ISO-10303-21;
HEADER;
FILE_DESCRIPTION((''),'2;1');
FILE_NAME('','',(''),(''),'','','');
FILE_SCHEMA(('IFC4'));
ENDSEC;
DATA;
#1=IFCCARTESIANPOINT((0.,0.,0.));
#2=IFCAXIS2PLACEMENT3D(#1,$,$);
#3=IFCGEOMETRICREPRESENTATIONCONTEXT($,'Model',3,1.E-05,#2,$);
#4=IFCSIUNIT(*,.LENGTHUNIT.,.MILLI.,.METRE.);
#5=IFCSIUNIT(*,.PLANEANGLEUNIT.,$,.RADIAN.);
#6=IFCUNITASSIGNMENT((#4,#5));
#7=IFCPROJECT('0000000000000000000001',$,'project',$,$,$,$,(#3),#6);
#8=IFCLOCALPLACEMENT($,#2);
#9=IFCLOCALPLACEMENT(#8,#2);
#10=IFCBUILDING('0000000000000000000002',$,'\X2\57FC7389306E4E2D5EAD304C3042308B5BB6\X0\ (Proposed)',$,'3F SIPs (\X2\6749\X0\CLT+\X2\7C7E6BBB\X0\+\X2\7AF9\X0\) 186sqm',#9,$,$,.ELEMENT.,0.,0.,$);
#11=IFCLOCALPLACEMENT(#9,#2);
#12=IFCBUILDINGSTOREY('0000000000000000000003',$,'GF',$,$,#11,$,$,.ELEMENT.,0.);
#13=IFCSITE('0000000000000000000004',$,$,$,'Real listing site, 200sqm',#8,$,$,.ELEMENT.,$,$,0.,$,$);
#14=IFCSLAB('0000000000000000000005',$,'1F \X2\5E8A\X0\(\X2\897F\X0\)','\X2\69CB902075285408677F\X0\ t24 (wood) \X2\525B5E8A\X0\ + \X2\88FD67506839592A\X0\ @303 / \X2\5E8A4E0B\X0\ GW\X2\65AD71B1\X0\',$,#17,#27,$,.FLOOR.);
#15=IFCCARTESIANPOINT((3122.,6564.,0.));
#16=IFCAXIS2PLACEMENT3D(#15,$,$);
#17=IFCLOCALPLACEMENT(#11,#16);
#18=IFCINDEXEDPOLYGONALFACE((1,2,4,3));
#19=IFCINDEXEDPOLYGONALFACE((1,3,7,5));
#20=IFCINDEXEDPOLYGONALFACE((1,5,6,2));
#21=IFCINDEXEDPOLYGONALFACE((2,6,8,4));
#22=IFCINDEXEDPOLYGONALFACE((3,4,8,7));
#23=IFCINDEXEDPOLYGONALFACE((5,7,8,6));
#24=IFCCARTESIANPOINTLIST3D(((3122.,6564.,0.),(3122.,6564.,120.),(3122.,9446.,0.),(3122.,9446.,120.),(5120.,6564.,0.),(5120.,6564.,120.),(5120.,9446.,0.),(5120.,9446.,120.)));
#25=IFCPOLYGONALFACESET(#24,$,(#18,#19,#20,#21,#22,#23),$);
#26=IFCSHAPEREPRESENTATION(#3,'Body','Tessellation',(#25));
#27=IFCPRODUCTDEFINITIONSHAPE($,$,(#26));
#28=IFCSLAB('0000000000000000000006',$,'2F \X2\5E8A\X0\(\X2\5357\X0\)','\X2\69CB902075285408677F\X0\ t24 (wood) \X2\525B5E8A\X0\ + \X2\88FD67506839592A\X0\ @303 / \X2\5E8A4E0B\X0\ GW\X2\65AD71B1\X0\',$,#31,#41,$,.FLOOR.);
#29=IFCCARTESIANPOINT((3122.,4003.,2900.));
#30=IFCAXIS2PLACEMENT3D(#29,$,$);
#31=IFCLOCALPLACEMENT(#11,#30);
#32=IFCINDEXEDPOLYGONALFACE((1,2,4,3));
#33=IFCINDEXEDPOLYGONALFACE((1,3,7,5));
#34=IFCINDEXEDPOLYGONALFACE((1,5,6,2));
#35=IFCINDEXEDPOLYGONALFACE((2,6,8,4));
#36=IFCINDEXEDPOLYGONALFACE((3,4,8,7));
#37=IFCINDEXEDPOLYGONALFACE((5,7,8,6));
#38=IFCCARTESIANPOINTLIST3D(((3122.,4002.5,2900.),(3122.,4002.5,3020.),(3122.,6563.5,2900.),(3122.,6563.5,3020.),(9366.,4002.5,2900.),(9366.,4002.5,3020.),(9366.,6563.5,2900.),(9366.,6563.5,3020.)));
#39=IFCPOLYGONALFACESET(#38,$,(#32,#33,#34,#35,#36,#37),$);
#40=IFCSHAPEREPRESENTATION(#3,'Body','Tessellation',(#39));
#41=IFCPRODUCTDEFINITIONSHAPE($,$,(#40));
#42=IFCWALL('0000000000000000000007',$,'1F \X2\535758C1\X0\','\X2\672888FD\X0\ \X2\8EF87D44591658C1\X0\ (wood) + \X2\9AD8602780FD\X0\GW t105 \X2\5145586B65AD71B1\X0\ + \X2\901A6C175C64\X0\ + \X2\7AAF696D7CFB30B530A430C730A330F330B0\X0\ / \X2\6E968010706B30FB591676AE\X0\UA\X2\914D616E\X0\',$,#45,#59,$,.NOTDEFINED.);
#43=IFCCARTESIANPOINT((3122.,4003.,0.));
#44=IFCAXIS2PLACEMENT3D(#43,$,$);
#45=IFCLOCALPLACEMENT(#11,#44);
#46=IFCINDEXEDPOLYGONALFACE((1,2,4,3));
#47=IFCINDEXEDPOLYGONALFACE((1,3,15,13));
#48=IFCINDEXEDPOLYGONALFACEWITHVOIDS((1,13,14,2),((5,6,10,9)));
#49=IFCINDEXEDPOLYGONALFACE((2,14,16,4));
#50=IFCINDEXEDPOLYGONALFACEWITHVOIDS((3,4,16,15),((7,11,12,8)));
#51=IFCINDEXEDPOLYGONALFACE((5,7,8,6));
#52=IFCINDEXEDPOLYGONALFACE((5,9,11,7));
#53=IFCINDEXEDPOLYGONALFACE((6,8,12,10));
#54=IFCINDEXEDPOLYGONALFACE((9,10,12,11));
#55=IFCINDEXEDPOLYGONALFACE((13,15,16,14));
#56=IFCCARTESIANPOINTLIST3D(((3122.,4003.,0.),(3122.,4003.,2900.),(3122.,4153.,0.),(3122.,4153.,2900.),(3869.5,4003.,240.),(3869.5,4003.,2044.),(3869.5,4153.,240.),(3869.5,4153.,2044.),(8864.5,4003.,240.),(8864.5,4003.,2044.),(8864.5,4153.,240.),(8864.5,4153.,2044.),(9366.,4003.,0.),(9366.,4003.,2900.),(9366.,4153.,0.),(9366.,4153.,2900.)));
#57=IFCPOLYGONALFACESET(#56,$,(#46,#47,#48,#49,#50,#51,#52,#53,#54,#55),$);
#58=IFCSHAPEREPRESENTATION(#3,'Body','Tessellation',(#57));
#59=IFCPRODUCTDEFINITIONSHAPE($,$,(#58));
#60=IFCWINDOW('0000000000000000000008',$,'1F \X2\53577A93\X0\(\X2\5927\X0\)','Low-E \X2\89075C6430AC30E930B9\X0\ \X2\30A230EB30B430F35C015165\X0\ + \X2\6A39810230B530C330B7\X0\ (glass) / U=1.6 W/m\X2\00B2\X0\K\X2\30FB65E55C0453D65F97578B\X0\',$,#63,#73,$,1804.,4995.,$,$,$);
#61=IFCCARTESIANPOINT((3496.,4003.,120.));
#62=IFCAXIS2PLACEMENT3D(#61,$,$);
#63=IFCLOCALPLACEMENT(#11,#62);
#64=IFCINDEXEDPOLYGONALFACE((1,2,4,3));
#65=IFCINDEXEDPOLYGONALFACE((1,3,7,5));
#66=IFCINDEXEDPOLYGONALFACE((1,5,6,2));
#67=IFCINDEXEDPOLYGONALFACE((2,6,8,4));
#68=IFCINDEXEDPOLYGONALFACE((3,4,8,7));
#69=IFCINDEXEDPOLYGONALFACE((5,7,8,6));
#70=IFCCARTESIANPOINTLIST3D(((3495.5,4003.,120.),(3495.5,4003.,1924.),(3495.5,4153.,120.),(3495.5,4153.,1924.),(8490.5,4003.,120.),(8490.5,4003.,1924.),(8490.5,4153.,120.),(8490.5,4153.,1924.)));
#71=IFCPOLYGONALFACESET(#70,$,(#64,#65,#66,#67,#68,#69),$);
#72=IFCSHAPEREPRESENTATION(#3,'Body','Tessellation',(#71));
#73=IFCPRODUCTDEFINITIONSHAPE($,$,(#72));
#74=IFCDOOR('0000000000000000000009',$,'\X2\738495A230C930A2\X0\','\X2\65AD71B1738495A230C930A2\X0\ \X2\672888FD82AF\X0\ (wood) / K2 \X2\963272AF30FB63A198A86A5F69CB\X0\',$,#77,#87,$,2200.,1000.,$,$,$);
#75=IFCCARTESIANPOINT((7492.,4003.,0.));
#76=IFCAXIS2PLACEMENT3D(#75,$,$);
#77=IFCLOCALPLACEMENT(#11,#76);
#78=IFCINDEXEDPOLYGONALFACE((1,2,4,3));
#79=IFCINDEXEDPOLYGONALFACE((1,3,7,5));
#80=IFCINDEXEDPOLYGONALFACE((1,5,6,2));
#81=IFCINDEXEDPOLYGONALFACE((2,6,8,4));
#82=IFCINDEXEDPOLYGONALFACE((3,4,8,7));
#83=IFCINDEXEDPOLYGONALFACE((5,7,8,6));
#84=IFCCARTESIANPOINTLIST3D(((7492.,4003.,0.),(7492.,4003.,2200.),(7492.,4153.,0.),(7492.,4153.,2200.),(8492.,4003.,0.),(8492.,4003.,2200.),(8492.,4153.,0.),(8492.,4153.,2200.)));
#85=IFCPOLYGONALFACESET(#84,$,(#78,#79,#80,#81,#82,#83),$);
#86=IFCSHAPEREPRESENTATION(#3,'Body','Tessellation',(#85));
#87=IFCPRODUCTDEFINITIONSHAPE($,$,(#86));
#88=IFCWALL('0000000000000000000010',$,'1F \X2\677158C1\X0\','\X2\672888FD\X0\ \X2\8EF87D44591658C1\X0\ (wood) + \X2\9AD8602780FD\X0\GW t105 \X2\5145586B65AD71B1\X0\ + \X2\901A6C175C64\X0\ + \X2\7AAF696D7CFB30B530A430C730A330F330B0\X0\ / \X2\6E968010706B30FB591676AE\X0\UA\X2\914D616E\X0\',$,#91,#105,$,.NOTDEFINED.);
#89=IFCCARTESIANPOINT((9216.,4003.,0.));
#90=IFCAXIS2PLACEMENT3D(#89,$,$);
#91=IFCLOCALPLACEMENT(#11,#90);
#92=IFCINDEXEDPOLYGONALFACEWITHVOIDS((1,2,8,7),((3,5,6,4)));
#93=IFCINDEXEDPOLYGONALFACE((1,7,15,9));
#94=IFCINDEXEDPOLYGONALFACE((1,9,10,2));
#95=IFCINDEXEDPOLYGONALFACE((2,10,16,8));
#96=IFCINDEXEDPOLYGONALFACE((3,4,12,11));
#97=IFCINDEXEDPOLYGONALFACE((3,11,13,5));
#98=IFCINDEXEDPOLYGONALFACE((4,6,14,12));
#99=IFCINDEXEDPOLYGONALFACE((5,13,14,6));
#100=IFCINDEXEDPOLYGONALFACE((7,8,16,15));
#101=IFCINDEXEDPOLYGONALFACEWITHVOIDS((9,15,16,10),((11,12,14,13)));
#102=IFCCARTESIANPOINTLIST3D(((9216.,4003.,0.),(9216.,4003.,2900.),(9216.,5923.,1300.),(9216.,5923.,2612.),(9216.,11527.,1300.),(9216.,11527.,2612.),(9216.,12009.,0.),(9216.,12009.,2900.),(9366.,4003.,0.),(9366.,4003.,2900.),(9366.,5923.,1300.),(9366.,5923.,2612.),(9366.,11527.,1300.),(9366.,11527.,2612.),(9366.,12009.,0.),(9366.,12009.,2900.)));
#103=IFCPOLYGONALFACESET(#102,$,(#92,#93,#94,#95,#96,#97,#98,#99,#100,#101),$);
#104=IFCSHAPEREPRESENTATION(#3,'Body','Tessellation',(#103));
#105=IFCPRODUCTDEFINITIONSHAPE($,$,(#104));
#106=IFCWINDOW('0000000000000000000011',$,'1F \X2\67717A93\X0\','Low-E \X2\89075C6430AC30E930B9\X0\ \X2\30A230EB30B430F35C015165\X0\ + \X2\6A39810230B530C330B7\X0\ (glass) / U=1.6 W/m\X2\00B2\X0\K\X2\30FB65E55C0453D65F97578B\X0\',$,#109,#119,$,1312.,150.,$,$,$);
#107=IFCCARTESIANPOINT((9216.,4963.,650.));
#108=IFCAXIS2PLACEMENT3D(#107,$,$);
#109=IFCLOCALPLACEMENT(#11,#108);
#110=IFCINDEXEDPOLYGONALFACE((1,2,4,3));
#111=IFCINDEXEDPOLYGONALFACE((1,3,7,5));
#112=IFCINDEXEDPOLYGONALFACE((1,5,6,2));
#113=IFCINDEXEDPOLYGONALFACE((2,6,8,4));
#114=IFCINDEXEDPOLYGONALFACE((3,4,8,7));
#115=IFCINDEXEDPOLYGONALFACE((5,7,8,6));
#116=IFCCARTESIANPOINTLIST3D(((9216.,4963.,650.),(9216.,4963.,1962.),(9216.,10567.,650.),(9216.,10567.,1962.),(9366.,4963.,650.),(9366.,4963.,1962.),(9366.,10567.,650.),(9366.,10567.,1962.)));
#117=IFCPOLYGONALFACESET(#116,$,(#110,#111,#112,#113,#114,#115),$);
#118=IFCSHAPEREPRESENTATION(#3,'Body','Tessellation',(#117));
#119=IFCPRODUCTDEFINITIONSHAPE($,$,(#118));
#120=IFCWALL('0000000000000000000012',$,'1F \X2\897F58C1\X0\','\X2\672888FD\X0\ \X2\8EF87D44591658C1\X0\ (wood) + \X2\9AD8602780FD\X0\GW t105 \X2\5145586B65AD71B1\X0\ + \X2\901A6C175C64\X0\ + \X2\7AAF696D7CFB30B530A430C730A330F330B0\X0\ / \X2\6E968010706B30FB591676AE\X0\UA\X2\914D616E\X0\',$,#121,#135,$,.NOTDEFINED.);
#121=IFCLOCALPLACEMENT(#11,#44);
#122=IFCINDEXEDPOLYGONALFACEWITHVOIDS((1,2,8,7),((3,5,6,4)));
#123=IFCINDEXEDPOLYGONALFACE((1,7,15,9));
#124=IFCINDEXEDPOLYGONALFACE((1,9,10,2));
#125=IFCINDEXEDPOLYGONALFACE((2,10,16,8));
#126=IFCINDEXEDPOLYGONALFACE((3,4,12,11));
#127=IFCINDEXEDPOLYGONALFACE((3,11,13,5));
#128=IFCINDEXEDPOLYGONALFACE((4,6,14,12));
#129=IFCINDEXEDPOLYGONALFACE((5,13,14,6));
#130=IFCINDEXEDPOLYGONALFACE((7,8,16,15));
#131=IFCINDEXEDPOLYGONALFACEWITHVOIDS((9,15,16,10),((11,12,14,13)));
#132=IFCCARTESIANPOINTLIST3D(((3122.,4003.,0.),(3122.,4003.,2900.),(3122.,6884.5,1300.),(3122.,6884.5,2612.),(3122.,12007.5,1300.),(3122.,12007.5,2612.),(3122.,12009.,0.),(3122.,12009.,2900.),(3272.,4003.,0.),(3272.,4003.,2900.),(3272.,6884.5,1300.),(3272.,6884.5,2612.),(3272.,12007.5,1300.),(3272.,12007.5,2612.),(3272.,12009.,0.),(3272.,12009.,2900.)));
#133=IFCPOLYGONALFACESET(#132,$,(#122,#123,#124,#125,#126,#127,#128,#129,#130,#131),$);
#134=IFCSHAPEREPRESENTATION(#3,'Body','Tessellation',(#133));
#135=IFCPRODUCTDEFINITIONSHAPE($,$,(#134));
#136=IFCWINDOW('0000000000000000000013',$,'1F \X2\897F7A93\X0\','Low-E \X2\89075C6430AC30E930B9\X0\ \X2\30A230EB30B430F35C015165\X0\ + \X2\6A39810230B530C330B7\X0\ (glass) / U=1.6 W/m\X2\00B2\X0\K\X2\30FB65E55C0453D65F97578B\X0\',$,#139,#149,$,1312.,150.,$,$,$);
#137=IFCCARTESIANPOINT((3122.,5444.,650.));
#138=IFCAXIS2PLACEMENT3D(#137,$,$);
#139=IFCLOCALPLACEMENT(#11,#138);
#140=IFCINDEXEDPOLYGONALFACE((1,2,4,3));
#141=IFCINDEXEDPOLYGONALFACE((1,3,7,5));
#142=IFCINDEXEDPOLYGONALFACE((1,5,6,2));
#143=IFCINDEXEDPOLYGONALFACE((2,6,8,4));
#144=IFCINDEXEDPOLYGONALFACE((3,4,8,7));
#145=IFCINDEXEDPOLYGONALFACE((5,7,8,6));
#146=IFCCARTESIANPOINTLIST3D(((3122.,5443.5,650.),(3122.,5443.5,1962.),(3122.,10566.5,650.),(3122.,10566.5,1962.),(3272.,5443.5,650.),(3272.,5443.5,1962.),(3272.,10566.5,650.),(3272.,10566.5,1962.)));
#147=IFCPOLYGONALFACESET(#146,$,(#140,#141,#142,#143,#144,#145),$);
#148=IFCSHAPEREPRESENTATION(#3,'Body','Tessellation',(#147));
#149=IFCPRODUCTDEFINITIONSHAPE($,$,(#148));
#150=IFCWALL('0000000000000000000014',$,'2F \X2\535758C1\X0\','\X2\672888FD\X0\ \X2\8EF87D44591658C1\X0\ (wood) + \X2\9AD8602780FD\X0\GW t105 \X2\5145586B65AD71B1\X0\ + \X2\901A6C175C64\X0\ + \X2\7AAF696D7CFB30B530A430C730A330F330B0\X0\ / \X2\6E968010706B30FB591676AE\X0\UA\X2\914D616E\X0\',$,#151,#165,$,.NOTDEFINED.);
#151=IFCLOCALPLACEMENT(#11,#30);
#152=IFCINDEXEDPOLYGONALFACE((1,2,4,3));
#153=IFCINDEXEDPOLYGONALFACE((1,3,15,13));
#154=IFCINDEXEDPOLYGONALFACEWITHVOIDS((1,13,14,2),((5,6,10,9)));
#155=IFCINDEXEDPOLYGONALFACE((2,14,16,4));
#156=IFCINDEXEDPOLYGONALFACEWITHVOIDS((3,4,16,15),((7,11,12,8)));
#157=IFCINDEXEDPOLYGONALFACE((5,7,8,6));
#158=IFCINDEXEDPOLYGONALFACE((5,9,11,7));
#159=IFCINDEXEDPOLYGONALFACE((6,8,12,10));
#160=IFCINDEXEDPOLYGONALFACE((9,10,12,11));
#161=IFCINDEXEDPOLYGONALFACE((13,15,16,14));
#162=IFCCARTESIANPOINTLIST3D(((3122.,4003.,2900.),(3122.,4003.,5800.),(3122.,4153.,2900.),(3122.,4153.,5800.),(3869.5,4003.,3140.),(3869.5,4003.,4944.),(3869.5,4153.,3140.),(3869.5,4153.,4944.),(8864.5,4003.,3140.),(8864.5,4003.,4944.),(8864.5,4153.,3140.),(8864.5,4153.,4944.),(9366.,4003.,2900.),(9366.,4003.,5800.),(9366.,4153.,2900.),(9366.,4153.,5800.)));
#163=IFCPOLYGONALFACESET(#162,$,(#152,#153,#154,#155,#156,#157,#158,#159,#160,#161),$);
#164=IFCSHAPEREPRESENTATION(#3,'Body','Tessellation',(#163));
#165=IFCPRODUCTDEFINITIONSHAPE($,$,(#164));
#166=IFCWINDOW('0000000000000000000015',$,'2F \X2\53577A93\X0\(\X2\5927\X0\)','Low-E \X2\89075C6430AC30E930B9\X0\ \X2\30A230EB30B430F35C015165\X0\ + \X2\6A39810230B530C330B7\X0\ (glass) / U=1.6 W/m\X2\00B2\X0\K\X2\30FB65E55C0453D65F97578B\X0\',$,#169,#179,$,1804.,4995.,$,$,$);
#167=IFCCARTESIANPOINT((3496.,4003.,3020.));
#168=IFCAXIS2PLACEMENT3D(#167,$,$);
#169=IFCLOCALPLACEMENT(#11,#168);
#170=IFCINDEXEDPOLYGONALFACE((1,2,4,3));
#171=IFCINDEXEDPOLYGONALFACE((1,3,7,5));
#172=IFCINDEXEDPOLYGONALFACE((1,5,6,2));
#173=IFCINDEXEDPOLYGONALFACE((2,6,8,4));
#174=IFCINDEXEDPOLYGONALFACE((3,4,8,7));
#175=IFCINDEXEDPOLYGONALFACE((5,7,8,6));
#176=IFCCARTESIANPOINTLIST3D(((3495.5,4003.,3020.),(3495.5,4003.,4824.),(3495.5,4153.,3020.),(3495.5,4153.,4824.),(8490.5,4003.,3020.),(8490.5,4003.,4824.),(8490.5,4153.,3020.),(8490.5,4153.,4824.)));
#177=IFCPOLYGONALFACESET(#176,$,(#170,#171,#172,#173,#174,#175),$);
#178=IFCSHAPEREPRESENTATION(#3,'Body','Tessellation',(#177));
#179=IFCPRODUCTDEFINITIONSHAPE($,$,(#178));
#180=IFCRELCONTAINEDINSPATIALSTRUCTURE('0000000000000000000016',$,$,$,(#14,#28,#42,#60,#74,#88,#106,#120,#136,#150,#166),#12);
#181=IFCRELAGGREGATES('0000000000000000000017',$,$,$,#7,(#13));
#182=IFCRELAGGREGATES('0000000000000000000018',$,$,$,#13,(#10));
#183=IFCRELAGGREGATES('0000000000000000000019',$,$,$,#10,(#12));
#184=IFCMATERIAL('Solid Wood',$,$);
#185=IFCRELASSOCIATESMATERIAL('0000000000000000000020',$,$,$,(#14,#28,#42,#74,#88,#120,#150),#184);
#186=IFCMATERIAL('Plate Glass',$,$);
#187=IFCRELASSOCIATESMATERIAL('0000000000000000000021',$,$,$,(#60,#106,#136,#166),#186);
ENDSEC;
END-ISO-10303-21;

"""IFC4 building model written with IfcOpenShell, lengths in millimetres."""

from ifc_helpers import new_model, si_unit, frame, frame_2d, origin, place, context, project, spatial, rectangle, extrude, material, element, fill, save


model = new_model("IFC4")

# Units and contexts
model_context = context("Model", 3, precision=1e-05, world=origin())
ifc_project = project(units=[si_unit("LENGTHUNIT", "METRE", prefix="MILLI"), si_unit("PLANEANGLEUNIT", "RADIAN")], contexts=[model_context])

# Site, building, storey
site_placement = place(None, origin())
site = spatial("IfcSite", under=ifc_project, at=site_placement, ObjectType="Real listing site, 200sqm", CompositionType="ELEMENT", RefElevation=0.0)
building_placement = place(site_placement, origin())
building = spatial("IfcBuilding", under=site, at=building_placement, Name="埼玉の中庭がある家 (Proposed)", ObjectType="3F SIPs (杉CLT+籾殻+竹) 186sqm", CompositionType="ELEMENT", ElevationOfRefHeight=0.0, ElevationOfTerrain=0.0)
storey_placement = place(building_placement, origin())
storey = spatial("IfcBuildingStorey", under=building, at=storey_placement, Name="GF", CompositionType="ELEMENT", Elevation=0.0)

# Slabs
ifc_material_1 = material(Name="Solid Wood")
slab_1_placement = place(storey_placement, frame((3122.0, 6564.0, 0.0)))
element("IfcSlab", 1, at=slab_1_placement, inside=storey, material=ifc_material_1, Name="1F 床(西)", Description="構造用合板 t24 (wood) 剛床 + 製材根太 @303 / 床下 GW断熱", PredefinedType="FLOOR", context=model_context, shape_type="SweptSolid", body=[
    extrude(rectangle(XDim=1998.0, YDim=2882.0, at=frame_2d((999.0, 1441.0))), frame((3122.0, 6564.0, 0.0)), (0.0, 0.0, 1.0), 120.0),
])
slab_2_placement = place(storey_placement, frame((3122.0, 4003.0, 2900.0)))
element("IfcSlab", 2, at=slab_2_placement, inside=storey, material=ifc_material_1, Name="2F 床(南)", Description="構造用合板 t24 (wood) 剛床 + 製材根太 @303 / 床下 GW断熱", PredefinedType="FLOOR", context=model_context, shape_type="SweptSolid", body=[
    extrude(rectangle(XDim=6244.0, YDim=2561.0, at=frame_2d((3122.0, 1280.0))), frame((3122.0, 4003.0, 2900.0)), (0.0, 0.0, 1.0), 120.0),
])

# Wall, openings, window, door
wall_1_placement = place(storey_placement, frame((3122.0, 4003.0, 0.0)))
wall_1 = element("IfcWall", 3, at=wall_1_placement, inside=storey, material=ifc_material_1, Name="1F 南壁", Description="木製 軸組外壁 (wood) + 高性能GW t105 充填断熱 + 通気層 + 窯業系サイディング / 準耐火・外皮UA配慮", PredefinedType="NOTDEFINED", context=model_context, shape_type="SweptSolid", body=[
    extrude(rectangle(XDim=6244.0, YDim=150.0, at=frame_2d((3122.0, 75.0))), frame((3122.0, 4003.0, 0.0)), (0.0, 0.0, 1.0), 2900.0),
])
opening_1_placement = place(storey_placement, frame((3496.0, 4003.0, 120.0)))
opening_1 = element("IfcOpeningElement", 4, at=opening_1_placement, cuts=wall_1, PredefinedType="NOTDEFINED", context=model_context, shape_type="SweptSolid", body=[
    extrude(rectangle(XDim=4995.0, YDim=150.0, at=frame_2d((2497.0, 75.0))), frame((3496.0, 4003.0, 120.0)), (0.0, 0.0, 1.0), 1804.0),
])
opening_2_placement = place(storey_placement, frame((7492.0, 4003.0, 0.0)))
opening_2 = element("IfcOpeningElement", 5, at=opening_2_placement, cuts=wall_1, PredefinedType="NOTDEFINED", context=model_context, shape_type="SweptSolid", body=[
    extrude(rectangle(XDim=1000.0, YDim=150.0, at=frame_2d((500.0, 75.0))), frame((7492.0, 4003.0, 0.0)), (0.0, 0.0, 1.0), 2200.0),
])
ifc_material_2 = material(Name="Plate Glass")
window_1_placement = place(storey_placement, frame((3496.0, 4003.0, 120.0)))
window_1 = element("IfcWindow", 6, at=window_1_placement, inside=storey, material=ifc_material_2, Name="1F 南窓(大)", Description="Low-E 複層ガラス アルゴン封入 + 樹脂サッシ (glass) / U=1.6 W/m²K・日射取得型", OverallHeight=1804.0, OverallWidth=4995.0, context=model_context, shape_type="SweptSolid", body=[
    extrude(rectangle(XDim=4995.0, YDim=150.0, at=frame_2d((2497.0, 75.0))), frame((3496.0, 4003.0, 120.0)), (0.0, 0.0, 1.0), 1804.0),
])
fill(opening_1, window_1)
door_placement = place(storey_placement, frame((7492.0, 4003.0, 0.0)))
door = element("IfcDoor", 7, at=door_placement, inside=storey, material=ifc_material_1, Name="玄関ドア", Description="断熱玄関ドア 木製芯 (wood) / K2 防犯・採風機構", OverallHeight=2200.0, OverallWidth=1000.0, context=model_context, shape_type="SweptSolid", body=[
    extrude(rectangle(XDim=1000.0, YDim=150.0, at=frame_2d((500.0, 75.0))), frame((7492.0, 4003.0, 0.0)), (0.0, 0.0, 1.0), 2200.0),
])
fill(opening_2, door)

# Walls, openings, windows
wall_2_placement = place(storey_placement, frame((9216.0, 4003.0, 0.0)))
wall_2 = element("IfcWall", 8, at=wall_2_placement, inside=storey, material=ifc_material_1, Name="1F 東壁", Description="木製 軸組外壁 (wood) + 高性能GW t105 充填断熱 + 通気層 + 窯業系サイディング / 準耐火・外皮UA配慮", PredefinedType="NOTDEFINED", context=model_context, shape_type="SweptSolid", body=[
    extrude(rectangle(XDim=150.0, YDim=8006.0, at=frame_2d((75.0, 4003.0))), frame((9216.0, 4003.0, 0.0)), (0.0, 0.0, 1.0), 2900.0),
])
opening_3_placement = place(storey_placement, frame((9216.0, 4963.0, 650.0)))
opening_3 = element("IfcOpeningElement", 9, at=opening_3_placement, cuts=wall_2, PredefinedType="NOTDEFINED", context=model_context, shape_type="SweptSolid", body=[
    extrude(rectangle(XDim=150.0, YDim=5604.0, at=frame_2d((75.0, 2802.0))), frame((9216.0, 4963.0, 650.0)), (0.0, 0.0, 1.0), 1312.0),
])
window_2_placement = place(storey_placement, frame((9216.0, 4963.0, 650.0)))
window_2 = element("IfcWindow", 10, at=window_2_placement, inside=storey, material=ifc_material_2, Name="1F 東窓", Description="Low-E 複層ガラス アルゴン封入 + 樹脂サッシ (glass) / U=1.6 W/m²K・日射取得型", OverallHeight=1312.0, OverallWidth=150.0, context=model_context, shape_type="SweptSolid", body=[
    extrude(rectangle(XDim=150.0, YDim=5604.0, at=frame_2d((75.0, 2802.0))), frame((9216.0, 4963.0, 650.0)), (0.0, 0.0, 1.0), 1312.0),
])
fill(opening_3, window_2)
wall_3_placement = place(storey_placement, frame((3122.0, 4003.0, 0.0)))
wall_3 = element("IfcWall", 11, at=wall_3_placement, inside=storey, material=ifc_material_1, Name="1F 西壁", Description="木製 軸組外壁 (wood) + 高性能GW t105 充填断熱 + 通気層 + 窯業系サイディング / 準耐火・外皮UA配慮", PredefinedType="NOTDEFINED", context=model_context, shape_type="SweptSolid", body=[
    extrude(rectangle(XDim=150.0, YDim=8006.0, at=frame_2d((75.0, 4003.0))), frame((3122.0, 4003.0, 0.0)), (0.0, 0.0, 1.0), 2900.0),
])
opening_4_placement = place(storey_placement, frame((3122.0, 5444.0, 650.0)))
opening_4 = element("IfcOpeningElement", 12, at=opening_4_placement, cuts=wall_3, PredefinedType="NOTDEFINED", context=model_context, shape_type="SweptSolid", body=[
    extrude(rectangle(XDim=150.0, YDim=5123.0, at=frame_2d((75.0, 2561.0))), frame((3122.0, 5444.0, 650.0)), (0.0, 0.0, 1.0), 1312.0),
])
window_3_placement = place(storey_placement, frame((3122.0, 5444.0, 650.0)))
window_3 = element("IfcWindow", 13, at=window_3_placement, inside=storey, material=ifc_material_2, Name="1F 西窓", Description="Low-E 複層ガラス アルゴン封入 + 樹脂サッシ (glass) / U=1.6 W/m²K・日射取得型", OverallHeight=1312.0, OverallWidth=150.0, context=model_context, shape_type="SweptSolid", body=[
    extrude(rectangle(XDim=150.0, YDim=5123.0, at=frame_2d((75.0, 2561.0))), frame((3122.0, 5444.0, 650.0)), (0.0, 0.0, 1.0), 1312.0),
])
fill(opening_4, window_3)
wall_4_placement = place(storey_placement, frame((3122.0, 4003.0, 2900.0)))
wall_4 = element("IfcWall", 14, at=wall_4_placement, inside=storey, material=ifc_material_1, Name="2F 南壁", Description="木製 軸組外壁 (wood) + 高性能GW t105 充填断熱 + 通気層 + 窯業系サイディング / 準耐火・外皮UA配慮", PredefinedType="NOTDEFINED", context=model_context, shape_type="SweptSolid", body=[
    extrude(rectangle(XDim=6244.0, YDim=150.0, at=frame_2d((3122.0, 75.0))), frame((3122.0, 4003.0, 2900.0)), (0.0, 0.0, 1.0), 2900.0),
])
opening_5_placement = place(storey_placement, frame((3496.0, 4003.0, 3020.0)))
opening_5 = element("IfcOpeningElement", 15, at=opening_5_placement, cuts=wall_4, PredefinedType="NOTDEFINED", context=model_context, shape_type="SweptSolid", body=[
    extrude(rectangle(XDim=4995.0, YDim=150.0, at=frame_2d((2497.0, 75.0))), frame((3496.0, 4003.0, 3020.0)), (0.0, 0.0, 1.0), 1804.0),
])
window_4_placement = place(storey_placement, frame((3496.0, 4003.0, 3020.0)))
window_4 = element("IfcWindow", 16, at=window_4_placement, inside=storey, material=ifc_material_2, Name="2F 南窓(大)", Description="Low-E 複層ガラス アルゴン封入 + 樹脂サッシ (glass) / U=1.6 W/m²K・日射取得型", OverallHeight=1804.0, OverallWidth=4995.0, context=model_context, shape_type="SweptSolid", body=[
    extrude(rectangle(XDim=4995.0, YDim=150.0, at=frame_2d((2497.0, 75.0))), frame((3496.0, 4003.0, 3020.0)), (0.0, 0.0, 1.0), 1804.0),
])
fill(opening_5, window_4)

save(model, "model.ifc")
